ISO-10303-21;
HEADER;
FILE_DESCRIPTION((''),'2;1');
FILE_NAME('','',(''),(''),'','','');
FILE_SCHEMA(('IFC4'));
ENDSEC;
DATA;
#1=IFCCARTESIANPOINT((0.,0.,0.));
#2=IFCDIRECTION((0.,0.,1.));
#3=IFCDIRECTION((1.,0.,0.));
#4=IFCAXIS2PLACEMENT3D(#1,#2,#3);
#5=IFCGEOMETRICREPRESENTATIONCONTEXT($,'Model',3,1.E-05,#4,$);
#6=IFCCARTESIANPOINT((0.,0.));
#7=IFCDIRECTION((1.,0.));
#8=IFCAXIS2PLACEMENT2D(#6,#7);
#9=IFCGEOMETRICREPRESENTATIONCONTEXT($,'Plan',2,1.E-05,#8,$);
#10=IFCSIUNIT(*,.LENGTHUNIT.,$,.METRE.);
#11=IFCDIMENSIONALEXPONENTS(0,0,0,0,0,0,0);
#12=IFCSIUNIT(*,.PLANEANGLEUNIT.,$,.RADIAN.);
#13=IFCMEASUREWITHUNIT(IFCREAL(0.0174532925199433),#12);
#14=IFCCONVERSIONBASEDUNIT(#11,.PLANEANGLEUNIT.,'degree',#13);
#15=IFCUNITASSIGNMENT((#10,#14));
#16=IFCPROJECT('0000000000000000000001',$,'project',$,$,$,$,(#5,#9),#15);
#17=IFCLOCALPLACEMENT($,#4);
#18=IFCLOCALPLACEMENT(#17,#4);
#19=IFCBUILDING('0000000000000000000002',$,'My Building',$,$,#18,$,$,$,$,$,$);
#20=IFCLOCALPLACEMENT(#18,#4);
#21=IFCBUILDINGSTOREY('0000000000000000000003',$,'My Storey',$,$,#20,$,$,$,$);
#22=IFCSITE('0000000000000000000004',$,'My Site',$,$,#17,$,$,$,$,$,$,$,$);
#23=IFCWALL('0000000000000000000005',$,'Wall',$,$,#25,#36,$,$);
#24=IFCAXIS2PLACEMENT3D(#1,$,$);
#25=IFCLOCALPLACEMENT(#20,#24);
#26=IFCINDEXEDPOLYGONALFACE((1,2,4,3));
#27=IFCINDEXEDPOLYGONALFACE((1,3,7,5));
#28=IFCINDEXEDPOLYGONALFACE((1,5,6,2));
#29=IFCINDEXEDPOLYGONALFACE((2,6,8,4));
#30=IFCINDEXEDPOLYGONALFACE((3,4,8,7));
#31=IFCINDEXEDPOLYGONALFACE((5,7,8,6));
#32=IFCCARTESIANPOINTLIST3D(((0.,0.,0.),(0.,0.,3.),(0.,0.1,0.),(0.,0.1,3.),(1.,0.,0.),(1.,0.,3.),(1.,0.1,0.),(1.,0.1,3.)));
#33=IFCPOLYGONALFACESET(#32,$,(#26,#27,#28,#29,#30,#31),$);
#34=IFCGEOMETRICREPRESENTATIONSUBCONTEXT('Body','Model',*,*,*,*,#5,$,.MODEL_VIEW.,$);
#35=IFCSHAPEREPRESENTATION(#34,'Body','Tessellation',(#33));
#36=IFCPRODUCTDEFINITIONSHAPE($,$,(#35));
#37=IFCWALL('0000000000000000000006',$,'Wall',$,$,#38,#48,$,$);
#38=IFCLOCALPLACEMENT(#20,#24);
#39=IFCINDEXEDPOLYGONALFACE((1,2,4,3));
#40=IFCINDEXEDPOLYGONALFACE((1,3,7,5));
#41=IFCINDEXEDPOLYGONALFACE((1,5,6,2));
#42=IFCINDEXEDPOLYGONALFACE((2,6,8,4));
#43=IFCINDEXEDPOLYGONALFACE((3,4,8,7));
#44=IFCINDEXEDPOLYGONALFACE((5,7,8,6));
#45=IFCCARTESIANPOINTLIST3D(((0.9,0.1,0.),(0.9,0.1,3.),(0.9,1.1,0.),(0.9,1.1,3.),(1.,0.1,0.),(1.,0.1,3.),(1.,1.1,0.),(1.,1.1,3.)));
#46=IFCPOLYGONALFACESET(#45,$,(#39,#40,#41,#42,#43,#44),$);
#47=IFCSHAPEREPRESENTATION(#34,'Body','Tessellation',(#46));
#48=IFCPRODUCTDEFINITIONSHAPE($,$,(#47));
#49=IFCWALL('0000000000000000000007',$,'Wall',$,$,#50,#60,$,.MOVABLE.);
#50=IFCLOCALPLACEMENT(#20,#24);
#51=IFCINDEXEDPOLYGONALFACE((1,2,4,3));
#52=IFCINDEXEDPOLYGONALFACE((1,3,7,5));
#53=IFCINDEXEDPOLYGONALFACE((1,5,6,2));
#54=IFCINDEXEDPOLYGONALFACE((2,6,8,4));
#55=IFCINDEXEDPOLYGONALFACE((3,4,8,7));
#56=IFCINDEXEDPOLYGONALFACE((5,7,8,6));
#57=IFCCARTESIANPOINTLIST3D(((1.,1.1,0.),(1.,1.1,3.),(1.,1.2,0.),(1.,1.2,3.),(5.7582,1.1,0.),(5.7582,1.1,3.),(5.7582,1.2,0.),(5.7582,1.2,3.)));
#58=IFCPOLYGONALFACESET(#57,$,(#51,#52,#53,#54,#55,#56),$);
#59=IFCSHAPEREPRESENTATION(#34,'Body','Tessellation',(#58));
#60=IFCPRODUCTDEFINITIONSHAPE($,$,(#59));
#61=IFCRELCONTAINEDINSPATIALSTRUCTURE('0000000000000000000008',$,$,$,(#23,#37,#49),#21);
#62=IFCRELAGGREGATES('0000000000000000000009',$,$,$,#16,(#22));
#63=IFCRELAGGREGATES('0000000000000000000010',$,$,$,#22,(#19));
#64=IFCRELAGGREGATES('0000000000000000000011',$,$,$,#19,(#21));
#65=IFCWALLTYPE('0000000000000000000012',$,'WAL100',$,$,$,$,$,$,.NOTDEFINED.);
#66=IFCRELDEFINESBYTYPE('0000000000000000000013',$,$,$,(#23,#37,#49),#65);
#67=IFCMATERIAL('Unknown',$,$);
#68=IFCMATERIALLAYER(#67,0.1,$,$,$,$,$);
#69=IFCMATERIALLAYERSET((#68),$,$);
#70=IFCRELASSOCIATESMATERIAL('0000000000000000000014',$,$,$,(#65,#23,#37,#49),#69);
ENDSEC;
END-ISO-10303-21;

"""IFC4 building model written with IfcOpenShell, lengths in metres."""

from ifc_helpers import new_model, entity, si_unit, converted_unit, frame, origin_with_axes, origin_2d_with_axis, place, context, subcontext, project, spatial, indexed_curve, outline, extrude, material, layer, layer_set, layer_usage, type_object, element, save


model = new_model("IFC4")

# Units and contexts
model_context = context("Model", 3, precision=1e-05, world=origin_with_axes())
plan_context = context("Plan", 2, precision=1e-05, world=origin_2d_with_axis())
body_context = subcontext(model_context, "Body", "Model", "MODEL_VIEW")
ifc_project = project(units=[si_unit("LENGTHUNIT", "METRE"), converted_unit("PLANEANGLEUNIT", "degree", entity("IfcReal", 0.0174532925199433), si_unit("PLANEANGLEUNIT", "RADIAN"), dimensions=[0, 0, 0, 0, 0, 0, 0])], contexts=[model_context, plan_context])

# Site, building, storey
site_placement = place(None, origin_with_axes())
site = spatial("IfcSite", under=ifc_project, at=site_placement, Name="My Site")
building_placement = place(site_placement, origin_with_axes())
building = spatial("IfcBuilding", under=site, at=building_placement, Name="My Building")
storey_placement = place(building_placement, origin_with_axes())
storey = spatial("IfcBuildingStorey", under=building, at=storey_placement, Name="My Storey")

# Walls
ifc_material = material(Name="Unknown")
ifc_layer = layer(ifc_material, 0.1)
ifc_layer_set = layer_set([ifc_layer])
ifc_layer_usage_1 = layer_usage(ifc_layer_set, "AXIS2", "POSITIVE", 0.0)
wall_type = type_object("IfcWallType", Name="WAL100", PredefinedType="NOTDEFINED", material=ifc_layer_set)
wall_1_placement = place(storey_placement, origin_with_axes())
element("IfcWall", 1, at=wall_1_placement, inside=storey, type_object=wall_type, material=ifc_layer_usage_1, Name="Wall", context=body_context, shape_type="SweptSolid", body=[
    extrude(outline(indexed_curve([(0.0, 0.0), (0.0, 0.1), (1.0, 0.1), (1.0, 0.0), (0.0, 0.0)], self_intersect=False)), origin_with_axes(), (0.0, 0.0, 1.0), 3.0),
])
ifc_layer_usage_2 = layer_usage(ifc_layer_set, "AXIS2", "POSITIVE", 0.0)
wall_2_placement = place(storey_placement, frame((1.0, 0.1, 0.0), z_axis=(0.0, 0.0, 1.0), x_axis=(0.0, 1.0, 0.0)))
element("IfcWall", 2, at=wall_2_placement, inside=storey, type_object=wall_type, material=ifc_layer_usage_2, Name="Wall", context=body_context, shape_type="SweptSolid", body=[
    extrude(outline(indexed_curve([(0.0, 0.0), (0.0, 0.1), (1.0, 0.1), (1.0, 0.0), (0.0, 0.0)], self_intersect=False)), origin_with_axes(), (0.0, 0.0, 1.0), 3.0),
])
ifc_layer_usage_3 = layer_usage(ifc_layer_set, "AXIS2", "POSITIVE", 0.0)
wall_3_placement = place(storey_placement, frame((1.0, 1.1, 0.0), z_axis=(0.0, 0.0, 1.0), x_axis=(1.0, 0.0, 0.0)))
element("IfcWall", 3, at=wall_3_placement, inside=storey, type_object=wall_type, material=ifc_layer_usage_3, Name="Wall", PredefinedType="MOVABLE", context=body_context, shape_type="SweptSolid", body=[
    extrude(outline(indexed_curve([(0.0, 0.0), (0.0, 0.1), (4.7582, 0.1), (4.7582, 0.0), (0.0, 0.0)], self_intersect=False)), origin_with_axes(), (0.0, 0.0, 1.0), 3.0),
])

save(model, "model.ifc")
